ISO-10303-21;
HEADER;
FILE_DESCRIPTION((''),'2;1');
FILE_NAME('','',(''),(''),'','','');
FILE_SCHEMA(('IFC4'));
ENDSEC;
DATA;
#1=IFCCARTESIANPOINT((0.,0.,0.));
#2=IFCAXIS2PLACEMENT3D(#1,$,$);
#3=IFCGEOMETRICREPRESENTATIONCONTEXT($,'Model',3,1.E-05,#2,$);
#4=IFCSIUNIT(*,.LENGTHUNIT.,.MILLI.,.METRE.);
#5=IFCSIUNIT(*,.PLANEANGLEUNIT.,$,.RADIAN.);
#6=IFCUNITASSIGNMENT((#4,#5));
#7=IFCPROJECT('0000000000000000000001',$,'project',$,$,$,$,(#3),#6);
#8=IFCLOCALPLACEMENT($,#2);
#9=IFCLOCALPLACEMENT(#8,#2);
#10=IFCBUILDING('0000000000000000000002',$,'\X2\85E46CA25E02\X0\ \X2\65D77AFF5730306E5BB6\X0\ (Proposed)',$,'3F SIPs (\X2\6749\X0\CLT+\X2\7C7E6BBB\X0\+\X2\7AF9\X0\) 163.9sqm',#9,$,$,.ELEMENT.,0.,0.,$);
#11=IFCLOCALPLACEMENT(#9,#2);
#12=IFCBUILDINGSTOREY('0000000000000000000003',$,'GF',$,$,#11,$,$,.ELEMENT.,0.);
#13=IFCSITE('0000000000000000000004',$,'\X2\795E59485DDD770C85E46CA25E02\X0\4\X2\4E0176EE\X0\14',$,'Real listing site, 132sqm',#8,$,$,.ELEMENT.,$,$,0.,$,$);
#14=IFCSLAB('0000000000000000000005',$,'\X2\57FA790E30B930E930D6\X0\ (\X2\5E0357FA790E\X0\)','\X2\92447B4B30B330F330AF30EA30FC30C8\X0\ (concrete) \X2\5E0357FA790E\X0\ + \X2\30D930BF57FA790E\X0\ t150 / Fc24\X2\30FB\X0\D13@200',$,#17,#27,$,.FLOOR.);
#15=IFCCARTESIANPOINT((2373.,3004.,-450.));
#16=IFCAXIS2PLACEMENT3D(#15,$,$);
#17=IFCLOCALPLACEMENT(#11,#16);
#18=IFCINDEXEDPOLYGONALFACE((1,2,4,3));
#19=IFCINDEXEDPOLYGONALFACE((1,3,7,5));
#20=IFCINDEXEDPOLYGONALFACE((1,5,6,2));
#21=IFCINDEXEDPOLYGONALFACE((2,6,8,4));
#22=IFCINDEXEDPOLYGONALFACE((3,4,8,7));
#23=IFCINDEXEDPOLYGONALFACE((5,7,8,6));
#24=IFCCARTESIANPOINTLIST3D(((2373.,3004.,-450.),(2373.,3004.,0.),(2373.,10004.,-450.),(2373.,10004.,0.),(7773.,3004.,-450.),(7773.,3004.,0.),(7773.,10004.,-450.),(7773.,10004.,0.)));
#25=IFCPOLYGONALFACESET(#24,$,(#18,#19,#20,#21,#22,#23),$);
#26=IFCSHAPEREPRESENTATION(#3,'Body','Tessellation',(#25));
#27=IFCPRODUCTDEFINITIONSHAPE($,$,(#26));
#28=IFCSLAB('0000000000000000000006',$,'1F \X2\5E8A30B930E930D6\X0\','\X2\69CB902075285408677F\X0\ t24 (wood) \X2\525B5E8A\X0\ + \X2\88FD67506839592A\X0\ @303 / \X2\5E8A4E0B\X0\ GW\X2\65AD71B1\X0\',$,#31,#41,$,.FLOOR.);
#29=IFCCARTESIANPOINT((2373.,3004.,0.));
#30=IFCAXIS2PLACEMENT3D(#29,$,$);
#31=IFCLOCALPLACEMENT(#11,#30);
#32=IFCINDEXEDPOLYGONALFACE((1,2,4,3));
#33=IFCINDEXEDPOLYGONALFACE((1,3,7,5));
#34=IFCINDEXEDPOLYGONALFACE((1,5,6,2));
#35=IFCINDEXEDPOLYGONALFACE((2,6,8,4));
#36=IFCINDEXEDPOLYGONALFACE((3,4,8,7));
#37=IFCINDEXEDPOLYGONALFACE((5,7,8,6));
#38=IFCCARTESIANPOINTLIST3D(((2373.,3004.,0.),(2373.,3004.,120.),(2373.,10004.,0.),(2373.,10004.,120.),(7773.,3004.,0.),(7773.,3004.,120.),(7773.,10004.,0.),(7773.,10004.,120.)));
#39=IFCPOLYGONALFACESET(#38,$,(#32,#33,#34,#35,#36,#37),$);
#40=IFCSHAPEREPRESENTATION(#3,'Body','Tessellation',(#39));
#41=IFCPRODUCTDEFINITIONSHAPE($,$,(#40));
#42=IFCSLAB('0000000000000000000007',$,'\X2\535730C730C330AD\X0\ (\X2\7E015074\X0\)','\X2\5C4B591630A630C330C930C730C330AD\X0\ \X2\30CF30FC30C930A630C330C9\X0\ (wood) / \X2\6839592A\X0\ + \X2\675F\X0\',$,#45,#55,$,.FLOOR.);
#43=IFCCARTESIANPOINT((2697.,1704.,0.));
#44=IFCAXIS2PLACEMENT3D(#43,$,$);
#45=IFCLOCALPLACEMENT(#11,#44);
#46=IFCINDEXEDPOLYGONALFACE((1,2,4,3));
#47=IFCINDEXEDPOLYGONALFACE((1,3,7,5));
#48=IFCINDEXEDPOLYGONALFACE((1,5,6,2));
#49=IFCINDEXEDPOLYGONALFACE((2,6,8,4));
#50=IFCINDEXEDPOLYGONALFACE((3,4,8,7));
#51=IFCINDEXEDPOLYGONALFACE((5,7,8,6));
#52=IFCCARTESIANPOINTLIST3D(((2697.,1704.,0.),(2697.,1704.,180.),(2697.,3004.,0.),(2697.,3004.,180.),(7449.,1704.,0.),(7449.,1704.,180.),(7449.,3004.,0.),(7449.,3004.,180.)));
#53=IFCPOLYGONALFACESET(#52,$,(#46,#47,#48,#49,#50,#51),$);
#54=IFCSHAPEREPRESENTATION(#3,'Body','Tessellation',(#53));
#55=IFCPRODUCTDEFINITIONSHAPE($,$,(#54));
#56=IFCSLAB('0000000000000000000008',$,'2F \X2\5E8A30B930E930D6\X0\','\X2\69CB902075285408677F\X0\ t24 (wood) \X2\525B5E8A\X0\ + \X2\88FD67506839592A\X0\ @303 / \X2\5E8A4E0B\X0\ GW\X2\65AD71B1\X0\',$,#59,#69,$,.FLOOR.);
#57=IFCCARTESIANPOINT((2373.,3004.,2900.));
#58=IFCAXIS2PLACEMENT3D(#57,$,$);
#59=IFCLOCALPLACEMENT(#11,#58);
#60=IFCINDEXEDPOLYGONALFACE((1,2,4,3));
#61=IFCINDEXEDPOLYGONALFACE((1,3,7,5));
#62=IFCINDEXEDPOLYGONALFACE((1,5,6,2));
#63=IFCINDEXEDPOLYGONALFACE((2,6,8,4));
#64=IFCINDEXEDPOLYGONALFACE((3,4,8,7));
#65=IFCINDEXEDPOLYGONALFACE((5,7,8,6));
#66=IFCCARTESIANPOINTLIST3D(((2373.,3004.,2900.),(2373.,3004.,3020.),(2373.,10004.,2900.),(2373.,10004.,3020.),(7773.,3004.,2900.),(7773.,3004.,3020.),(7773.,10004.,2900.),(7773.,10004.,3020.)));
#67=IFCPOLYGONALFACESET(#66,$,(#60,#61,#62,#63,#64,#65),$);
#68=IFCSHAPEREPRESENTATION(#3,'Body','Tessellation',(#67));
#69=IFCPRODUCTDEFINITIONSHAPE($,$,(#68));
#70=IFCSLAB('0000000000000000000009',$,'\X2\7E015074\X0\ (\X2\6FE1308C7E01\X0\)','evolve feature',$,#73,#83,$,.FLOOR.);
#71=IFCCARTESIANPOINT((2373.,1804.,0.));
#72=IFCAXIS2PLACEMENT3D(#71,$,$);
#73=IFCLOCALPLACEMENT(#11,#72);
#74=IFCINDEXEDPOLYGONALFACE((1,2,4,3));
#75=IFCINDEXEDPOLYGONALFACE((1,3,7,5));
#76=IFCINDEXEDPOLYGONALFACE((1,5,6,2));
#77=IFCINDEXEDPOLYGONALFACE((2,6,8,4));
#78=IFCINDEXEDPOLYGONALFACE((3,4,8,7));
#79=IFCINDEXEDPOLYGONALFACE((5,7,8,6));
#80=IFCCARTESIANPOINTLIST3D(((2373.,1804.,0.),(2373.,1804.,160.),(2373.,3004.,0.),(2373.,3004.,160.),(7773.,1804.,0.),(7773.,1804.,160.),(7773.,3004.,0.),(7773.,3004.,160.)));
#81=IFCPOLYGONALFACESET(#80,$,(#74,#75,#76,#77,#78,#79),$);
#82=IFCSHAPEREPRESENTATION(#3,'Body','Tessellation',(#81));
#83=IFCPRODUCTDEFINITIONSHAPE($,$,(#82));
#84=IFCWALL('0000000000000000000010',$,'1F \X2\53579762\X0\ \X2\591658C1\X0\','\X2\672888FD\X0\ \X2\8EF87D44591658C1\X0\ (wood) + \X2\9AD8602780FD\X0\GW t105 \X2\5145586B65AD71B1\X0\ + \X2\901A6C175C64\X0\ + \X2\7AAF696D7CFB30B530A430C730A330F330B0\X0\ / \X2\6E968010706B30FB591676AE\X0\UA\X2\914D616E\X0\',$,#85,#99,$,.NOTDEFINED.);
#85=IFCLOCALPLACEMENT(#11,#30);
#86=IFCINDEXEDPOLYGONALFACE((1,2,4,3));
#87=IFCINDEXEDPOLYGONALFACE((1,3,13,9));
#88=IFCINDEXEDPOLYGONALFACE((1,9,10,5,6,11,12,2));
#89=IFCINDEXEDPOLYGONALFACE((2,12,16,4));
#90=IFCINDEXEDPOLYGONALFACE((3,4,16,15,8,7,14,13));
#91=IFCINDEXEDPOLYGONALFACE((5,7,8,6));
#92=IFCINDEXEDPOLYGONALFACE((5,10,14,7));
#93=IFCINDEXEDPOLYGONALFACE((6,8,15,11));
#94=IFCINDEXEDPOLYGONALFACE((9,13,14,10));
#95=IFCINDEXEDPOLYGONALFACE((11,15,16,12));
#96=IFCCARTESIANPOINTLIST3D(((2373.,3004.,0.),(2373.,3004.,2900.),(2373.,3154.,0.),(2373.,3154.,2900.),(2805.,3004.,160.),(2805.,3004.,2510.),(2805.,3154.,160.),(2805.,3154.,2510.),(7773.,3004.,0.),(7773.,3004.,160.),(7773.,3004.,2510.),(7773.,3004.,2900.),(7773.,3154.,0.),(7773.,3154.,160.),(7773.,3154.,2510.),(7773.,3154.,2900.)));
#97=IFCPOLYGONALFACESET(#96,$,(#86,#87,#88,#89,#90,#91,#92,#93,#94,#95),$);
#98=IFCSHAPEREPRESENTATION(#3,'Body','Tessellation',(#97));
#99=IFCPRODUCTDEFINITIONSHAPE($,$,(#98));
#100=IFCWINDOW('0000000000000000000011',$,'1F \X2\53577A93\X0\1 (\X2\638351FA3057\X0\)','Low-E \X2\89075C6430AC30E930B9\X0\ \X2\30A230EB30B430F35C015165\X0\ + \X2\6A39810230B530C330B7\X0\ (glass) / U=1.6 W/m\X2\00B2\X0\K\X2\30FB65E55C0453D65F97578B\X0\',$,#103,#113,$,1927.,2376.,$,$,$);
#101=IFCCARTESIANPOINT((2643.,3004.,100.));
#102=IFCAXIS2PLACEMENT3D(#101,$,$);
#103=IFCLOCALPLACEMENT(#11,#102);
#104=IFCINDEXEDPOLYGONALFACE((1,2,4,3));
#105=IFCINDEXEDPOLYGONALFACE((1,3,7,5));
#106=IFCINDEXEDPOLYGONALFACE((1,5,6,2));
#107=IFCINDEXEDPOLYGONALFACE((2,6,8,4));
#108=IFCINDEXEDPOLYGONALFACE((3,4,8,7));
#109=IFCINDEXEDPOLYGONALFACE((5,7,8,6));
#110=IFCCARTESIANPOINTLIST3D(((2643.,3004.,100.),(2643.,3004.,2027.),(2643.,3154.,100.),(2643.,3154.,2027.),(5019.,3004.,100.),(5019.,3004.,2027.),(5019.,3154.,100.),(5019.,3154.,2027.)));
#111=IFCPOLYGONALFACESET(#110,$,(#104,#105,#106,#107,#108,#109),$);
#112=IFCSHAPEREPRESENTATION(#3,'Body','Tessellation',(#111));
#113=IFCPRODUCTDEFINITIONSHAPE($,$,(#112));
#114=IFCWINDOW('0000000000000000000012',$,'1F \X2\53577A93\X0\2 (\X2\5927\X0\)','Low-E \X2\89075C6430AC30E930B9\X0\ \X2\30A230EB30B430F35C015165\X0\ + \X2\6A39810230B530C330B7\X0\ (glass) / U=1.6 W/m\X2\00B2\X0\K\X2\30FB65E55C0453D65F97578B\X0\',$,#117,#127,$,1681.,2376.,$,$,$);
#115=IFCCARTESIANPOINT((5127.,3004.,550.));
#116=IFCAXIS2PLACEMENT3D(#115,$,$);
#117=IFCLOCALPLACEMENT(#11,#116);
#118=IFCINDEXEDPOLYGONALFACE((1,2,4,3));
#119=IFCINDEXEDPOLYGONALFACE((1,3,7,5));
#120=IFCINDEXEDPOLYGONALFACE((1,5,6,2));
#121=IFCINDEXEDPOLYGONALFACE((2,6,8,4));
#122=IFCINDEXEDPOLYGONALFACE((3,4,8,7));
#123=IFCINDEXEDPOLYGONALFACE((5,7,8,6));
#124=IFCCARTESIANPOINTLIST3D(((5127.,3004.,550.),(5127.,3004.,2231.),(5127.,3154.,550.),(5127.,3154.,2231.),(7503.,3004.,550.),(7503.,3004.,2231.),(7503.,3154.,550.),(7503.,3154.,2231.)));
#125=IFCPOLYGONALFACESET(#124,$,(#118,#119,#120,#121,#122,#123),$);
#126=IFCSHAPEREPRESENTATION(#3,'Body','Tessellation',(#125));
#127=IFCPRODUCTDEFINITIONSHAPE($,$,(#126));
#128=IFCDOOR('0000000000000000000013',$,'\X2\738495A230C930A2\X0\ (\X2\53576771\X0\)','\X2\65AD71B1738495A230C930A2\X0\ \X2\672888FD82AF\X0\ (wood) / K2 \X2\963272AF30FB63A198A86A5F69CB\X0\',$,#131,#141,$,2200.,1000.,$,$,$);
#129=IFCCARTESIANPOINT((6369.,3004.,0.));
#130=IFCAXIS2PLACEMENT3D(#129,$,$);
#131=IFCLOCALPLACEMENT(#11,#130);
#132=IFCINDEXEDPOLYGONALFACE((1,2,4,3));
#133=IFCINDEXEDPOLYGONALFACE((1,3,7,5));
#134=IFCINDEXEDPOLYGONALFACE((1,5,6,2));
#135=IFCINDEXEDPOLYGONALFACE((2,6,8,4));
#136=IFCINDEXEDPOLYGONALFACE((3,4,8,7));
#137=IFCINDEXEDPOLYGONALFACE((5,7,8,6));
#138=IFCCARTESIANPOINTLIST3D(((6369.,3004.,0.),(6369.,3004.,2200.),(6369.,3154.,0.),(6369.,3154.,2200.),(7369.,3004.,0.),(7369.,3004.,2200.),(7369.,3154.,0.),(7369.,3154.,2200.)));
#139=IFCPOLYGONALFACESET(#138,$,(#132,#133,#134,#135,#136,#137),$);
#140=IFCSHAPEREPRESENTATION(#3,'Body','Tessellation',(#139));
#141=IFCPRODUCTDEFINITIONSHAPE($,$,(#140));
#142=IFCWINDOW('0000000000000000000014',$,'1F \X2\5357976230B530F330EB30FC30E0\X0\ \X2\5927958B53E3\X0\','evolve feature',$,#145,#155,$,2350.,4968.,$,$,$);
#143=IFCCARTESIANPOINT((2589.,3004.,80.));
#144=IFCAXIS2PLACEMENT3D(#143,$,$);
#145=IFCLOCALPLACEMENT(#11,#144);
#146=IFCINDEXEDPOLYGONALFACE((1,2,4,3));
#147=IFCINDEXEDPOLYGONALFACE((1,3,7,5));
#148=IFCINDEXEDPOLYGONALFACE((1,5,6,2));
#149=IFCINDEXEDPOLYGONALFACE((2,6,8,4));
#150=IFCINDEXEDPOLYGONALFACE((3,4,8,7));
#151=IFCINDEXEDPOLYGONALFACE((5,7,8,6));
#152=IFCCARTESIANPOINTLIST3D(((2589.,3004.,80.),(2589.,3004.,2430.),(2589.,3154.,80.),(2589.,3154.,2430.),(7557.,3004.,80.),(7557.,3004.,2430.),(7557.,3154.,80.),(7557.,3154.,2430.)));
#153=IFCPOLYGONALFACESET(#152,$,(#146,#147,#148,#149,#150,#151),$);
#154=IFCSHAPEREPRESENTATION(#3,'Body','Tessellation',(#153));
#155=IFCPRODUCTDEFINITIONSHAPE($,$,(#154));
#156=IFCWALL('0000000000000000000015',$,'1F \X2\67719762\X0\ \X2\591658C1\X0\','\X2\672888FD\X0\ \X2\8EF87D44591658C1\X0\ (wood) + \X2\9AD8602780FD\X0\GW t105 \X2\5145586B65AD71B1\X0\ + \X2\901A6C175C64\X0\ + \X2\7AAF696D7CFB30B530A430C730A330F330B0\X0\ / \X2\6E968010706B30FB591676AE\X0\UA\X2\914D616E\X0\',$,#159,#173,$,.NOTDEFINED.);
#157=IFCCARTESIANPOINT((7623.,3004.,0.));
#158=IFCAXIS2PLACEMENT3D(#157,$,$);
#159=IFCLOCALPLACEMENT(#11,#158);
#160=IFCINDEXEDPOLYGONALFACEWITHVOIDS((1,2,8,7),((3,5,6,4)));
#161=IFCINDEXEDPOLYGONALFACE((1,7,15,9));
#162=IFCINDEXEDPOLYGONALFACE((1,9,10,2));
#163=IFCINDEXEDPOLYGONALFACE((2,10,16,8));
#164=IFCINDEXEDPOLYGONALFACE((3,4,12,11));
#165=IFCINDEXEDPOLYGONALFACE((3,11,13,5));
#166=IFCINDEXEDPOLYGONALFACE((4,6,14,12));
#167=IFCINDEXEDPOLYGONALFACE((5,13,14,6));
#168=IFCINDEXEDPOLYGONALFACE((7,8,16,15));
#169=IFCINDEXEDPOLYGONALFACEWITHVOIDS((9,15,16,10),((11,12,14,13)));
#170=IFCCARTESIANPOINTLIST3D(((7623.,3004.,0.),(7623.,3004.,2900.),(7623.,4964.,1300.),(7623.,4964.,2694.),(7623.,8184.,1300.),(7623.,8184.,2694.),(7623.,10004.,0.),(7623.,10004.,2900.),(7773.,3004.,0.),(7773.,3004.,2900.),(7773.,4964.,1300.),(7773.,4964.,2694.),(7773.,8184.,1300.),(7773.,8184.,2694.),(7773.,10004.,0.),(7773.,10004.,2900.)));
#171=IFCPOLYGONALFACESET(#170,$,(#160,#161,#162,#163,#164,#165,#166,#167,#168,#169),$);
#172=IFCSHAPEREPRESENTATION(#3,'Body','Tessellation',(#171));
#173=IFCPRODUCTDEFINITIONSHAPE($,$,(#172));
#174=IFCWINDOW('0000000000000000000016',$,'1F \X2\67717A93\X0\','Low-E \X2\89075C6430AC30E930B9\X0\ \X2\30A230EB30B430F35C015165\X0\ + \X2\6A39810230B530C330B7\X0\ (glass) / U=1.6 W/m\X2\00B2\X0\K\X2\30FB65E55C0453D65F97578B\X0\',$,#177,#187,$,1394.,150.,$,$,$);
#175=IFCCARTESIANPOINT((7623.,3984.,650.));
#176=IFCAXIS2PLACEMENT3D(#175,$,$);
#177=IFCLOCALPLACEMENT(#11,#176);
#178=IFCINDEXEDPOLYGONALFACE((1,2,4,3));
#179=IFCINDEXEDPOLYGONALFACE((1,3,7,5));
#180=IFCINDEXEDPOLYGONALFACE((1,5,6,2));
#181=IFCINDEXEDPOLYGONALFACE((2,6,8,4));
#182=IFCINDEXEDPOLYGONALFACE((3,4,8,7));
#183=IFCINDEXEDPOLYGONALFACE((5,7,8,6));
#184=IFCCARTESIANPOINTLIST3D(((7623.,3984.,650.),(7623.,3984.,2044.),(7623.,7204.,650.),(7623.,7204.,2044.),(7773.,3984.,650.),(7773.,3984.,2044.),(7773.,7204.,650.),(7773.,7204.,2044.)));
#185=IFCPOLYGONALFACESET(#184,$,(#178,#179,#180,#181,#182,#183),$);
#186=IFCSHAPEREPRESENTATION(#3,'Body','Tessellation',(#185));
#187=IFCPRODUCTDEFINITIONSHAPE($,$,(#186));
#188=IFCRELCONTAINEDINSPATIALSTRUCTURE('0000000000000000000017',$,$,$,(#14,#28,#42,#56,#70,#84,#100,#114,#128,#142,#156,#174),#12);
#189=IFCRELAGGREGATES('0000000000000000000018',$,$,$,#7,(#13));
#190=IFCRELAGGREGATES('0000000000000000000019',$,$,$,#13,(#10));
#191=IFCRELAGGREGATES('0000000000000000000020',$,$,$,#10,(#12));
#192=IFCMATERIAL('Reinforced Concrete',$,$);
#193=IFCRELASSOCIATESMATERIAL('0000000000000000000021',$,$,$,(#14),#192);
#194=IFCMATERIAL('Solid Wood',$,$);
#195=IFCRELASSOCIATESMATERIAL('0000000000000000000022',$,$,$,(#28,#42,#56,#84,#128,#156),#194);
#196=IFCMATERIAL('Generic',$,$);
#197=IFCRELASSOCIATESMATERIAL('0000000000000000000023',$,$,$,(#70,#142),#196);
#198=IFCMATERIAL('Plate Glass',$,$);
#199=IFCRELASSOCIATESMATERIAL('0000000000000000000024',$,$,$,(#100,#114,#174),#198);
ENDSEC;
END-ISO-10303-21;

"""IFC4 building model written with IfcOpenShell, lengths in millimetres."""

from ifc_helpers import new_model, si_unit, frame, frame_2d, origin, place, context, project, spatial, rectangle, extrude, material, element, fill, save


model = new_model("IFC4")

# Units and contexts
model_context = context("Model", 3, precision=1e-05, world=origin())
ifc_project = project(units=[si_unit("LENGTHUNIT", "METRE", prefix="MILLI"), si_unit("PLANEANGLEUNIT", "RADIAN")], contexts=[model_context])

# Site, building, storey
site_placement = place(None, origin())
site = spatial("IfcSite", under=ifc_project, at=site_placement, Name="神奈川県藤沢市4丁目14", ObjectType="Real listing site, 132sqm", CompositionType="ELEMENT", RefElevation=0.0)
building_placement = place(site_placement, origin())
building = spatial("IfcBuilding", under=site, at=building_placement, Name="藤沢市 旗竿地の家 (Proposed)", ObjectType="3F SIPs (杉CLT+籾殻+竹) 163.9sqm", CompositionType="ELEMENT", ElevationOfRefHeight=0.0, ElevationOfTerrain=0.0)
storey_placement = place(building_placement, origin())
storey = spatial("IfcBuildingStorey", under=building, at=storey_placement, Name="GF", CompositionType="ELEMENT", Elevation=0.0)

# Slabs
ifc_material_1 = material(Name="Reinforced Concrete")
slab_1_placement = place(storey_placement, frame((2373.0, 3004.0, -450.0)))
element("IfcSlab", 1, at=slab_1_placement, inside=storey, material=ifc_material_1, Name="基礎スラブ (布基礎)", Description="鉄筋コンクリート (concrete) 布基礎 + ベタ基礎 t150 / Fc24・D13@200", PredefinedType="FLOOR", context=model_context, shape_type="SweptSolid", body=[
    extrude(rectangle(XDim=5400.0, YDim=7000.0, at=frame_2d((2700.0, 3500.0))), frame((2373.0, 3004.0, -450.0)), (0.0, 0.0, 1.0), 450.0),
])
ifc_material_2 = material(Name="Solid Wood")
slab_2_placement = place(storey_placement, frame((2373.0, 3004.0, 0.0)))
element("IfcSlab", 2, at=slab_2_placement, inside=storey, material=ifc_material_2, Name="1F 床スラブ", Description="構造用合板 t24 (wood) 剛床 + 製材根太 @303 / 床下 GW断熱", PredefinedType="FLOOR", context=model_context, shape_type="SweptSolid", body=[
    extrude(rectangle(XDim=5400.0, YDim=7000.0, at=frame_2d((2700.0, 3500.0))), frame((2373.0, 3004.0, 0.0)), (0.0, 0.0, 1.0), 120.0),
])
slab_3_placement = place(storey_placement, frame((2697.0, 1704.0, 0.0)))
element("IfcSlab", 3, at=slab_3_placement, inside=storey, material=ifc_material_2, Name="南デッキ (縁側)", Description="屋外ウッドデッキ ハードウッド (wood) / 根太 + 束", PredefinedType="FLOOR", context=model_context, shape_type="SweptSolid", body=[
    extrude(rectangle(XDim=4752.0, YDim=1300.0, at=frame_2d((2376.0, 650.0))), frame((2697.0, 1704.0, 0.0)), (0.0, 0.0, 1.0), 180.0),
])
slab_4_placement = place(storey_placement, frame((2373.0, 3004.0, 2900.0)))
element("IfcSlab", 4, at=slab_4_placement, inside=storey, material=ifc_material_2, Name="2F 床スラブ", Description="構造用合板 t24 (wood) 剛床 + 製材根太 @303 / 床下 GW断熱", PredefinedType="FLOOR", context=model_context, shape_type="SweptSolid", body=[
    extrude(rectangle(XDim=5400.0, YDim=7000.0, at=frame_2d((2700.0, 3500.0))), frame((2373.0, 3004.0, 2900.0)), (0.0, 0.0, 1.0), 120.0),
])
ifc_material_3 = material(Name="Generic")
slab_5_placement = place(storey_placement, frame((2373.0, 1804.0, 0.0)))
element("IfcSlab", 5, at=slab_5_placement, inside=storey, material=ifc_material_3, Name="縁側 (濡れ縁)", Description="evolve feature", PredefinedType="FLOOR", context=model_context, shape_type="SweptSolid", body=[
    extrude(rectangle(XDim=5400.0, YDim=1200.0, at=frame_2d((2700.0, 600.0))), frame((2373.0, 1804.0, 0.0)), (0.0, 0.0, 1.0), 160.0),
])

# Wall, openings, windows, door
wall_1_placement = place(storey_placement, frame((2373.0, 3004.0, 0.0)))
wall_1 = element("IfcWall", 6, at=wall_1_placement, inside=storey, material=ifc_material_2, Name="1F 南面 外壁", Description="木製 軸組外壁 (wood) + 高性能GW t105 充填断熱 + 通気層 + 窯業系サイディング / 準耐火・外皮UA配慮", PredefinedType="NOTDEFINED", context=model_context, shape_type="SweptSolid", body=[
    extrude(rectangle(XDim=5400.0, YDim=150.0, at=frame_2d((2700.0, 75.0))), frame((2373.0, 3004.0, 0.0)), (0.0, 0.0, 1.0), 2900.0),
])
opening_1_placement = place(storey_placement, frame((2643.0, 3004.0, 100.0)))
opening_1 = element("IfcOpeningElement", 7, at=opening_1_placement, cuts=wall_1, PredefinedType="NOTDEFINED", context=model_context, shape_type="SweptSolid", body=[
    extrude(rectangle(XDim=2376.0, YDim=150.0, at=frame_2d((1188.0, 75.0))), frame((2643.0, 3004.0, 100.0)), (0.0, 0.0, 1.0), 1927.0),
])
opening_2_placement = place(storey_placement, frame((5127.0, 3004.0, 550.0)))
opening_2 = element("IfcOpeningElement", 8, at=opening_2_placement, cuts=wall_1, PredefinedType="NOTDEFINED", context=model_context, shape_type="SweptSolid", body=[
    extrude(rectangle(XDim=2376.0, YDim=150.0, at=frame_2d((1188.0, 75.0))), frame((5127.0, 3004.0, 550.0)), (0.0, 0.0, 1.0), 1681.0),
])
opening_3_placement = place(storey_placement, frame((6369.0, 3004.0, 0.0)))
opening_3 = element("IfcOpeningElement", 9, at=opening_3_placement, cuts=wall_1, PredefinedType="NOTDEFINED", context=model_context, shape_type="SweptSolid", body=[
    extrude(rectangle(XDim=1000.0, YDim=150.0, at=frame_2d((500.0, 75.0))), frame((6369.0, 3004.0, 0.0)), (0.0, 0.0, 1.0), 2200.0),
])
opening_4_placement = place(storey_placement, frame((2589.0, 3004.0, 80.0)))
opening_4 = element("IfcOpeningElement", 10, at=opening_4_placement, cuts=wall_1, PredefinedType="NOTDEFINED", context=model_context, shape_type="SweptSolid", body=[
    extrude(rectangle(XDim=4968.0, YDim=150.0, at=frame_2d((2484.0, 75.0))), frame((2589.0, 3004.0, 80.0)), (0.0, 0.0, 1.0), 2350.0),
])
ifc_material_4 = material(Name="Plate Glass")
window_1_placement = place(storey_placement, frame((2643.0, 3004.0, 100.0)))
window_1 = element("IfcWindow", 11, at=window_1_placement, inside=storey, material=ifc_material_4, Name="1F 南窓1 (掃出し)", Description="Low-E 複層ガラス アルゴン封入 + 樹脂サッシ (glass) / U=1.6 W/m²K・日射取得型", OverallHeight=1927.0, OverallWidth=2376.0, context=model_context, shape_type="SweptSolid", body=[
    extrude(rectangle(XDim=2376.0, YDim=150.0, at=frame_2d((1188.0, 75.0))), frame((2643.0, 3004.0, 100.0)), (0.0, 0.0, 1.0), 1927.0),
])
fill(opening_1, window_1)
window_2_placement = place(storey_placement, frame((5127.0, 3004.0, 550.0)))
window_2 = element("IfcWindow", 12, at=window_2_placement, inside=storey, material=ifc_material_4, Name="1F 南窓2 (大)", Description="Low-E 複層ガラス アルゴン封入 + 樹脂サッシ (glass) / U=1.6 W/m²K・日射取得型", OverallHeight=1681.0, OverallWidth=2376.0, context=model_context, shape_type="SweptSolid", body=[
    extrude(rectangle(XDim=2376.0, YDim=150.0, at=frame_2d((1188.0, 75.0))), frame((5127.0, 3004.0, 550.0)), (0.0, 0.0, 1.0), 1681.0),
])
fill(opening_2, window_2)
door_placement = place(storey_placement, frame((6369.0, 3004.0, 0.0)))
door = element("IfcDoor", 13, at=door_placement, inside=storey, material=ifc_material_2, Name="玄関ドア (南東)", Description="断熱玄関ドア 木製芯 (wood) / K2 防犯・採風機構", OverallHeight=2200.0, OverallWidth=1000.0, context=model_context, shape_type="SweptSolid", body=[
    extrude(rectangle(XDim=1000.0, YDim=150.0, at=frame_2d((500.0, 75.0))), frame((6369.0, 3004.0, 0.0)), (0.0, 0.0, 1.0), 2200.0),
])
fill(opening_3, door)
window_3_placement = place(storey_placement, frame((2589.0, 3004.0, 80.0)))
window_3 = element("IfcWindow", 14, at=window_3_placement, inside=storey, material=ifc_material_3, Name="1F 南面サンルーム 大開口", Description="evolve feature", OverallHeight=2350.0, OverallWidth=4968.0, context=model_context, shape_type="SweptSolid", body=[
    extrude(rectangle(XDim=4968.0, YDim=150.0, at=frame_2d((2484.0, 75.0))), frame((2589.0, 3004.0, 80.0)), (0.0, 0.0, 1.0), 2350.0),
])
fill(opening_4, window_3)

# Wall, opening, window
wall_2_placement = place(storey_placement, frame((7623.0, 3004.0, 0.0)))
wall_2 = element("IfcWall", 15, at=wall_2_placement, inside=storey, material=ifc_material_2, Name="1F 東面 外壁", Description="木製 軸組外壁 (wood) + 高性能GW t105 充填断熱 + 通気層 + 窯業系サイディング / 準耐火・外皮UA配慮", PredefinedType="NOTDEFINED", context=model_context, shape_type="SweptSolid", body=[
    extrude(rectangle(XDim=150.0, YDim=7000.0, at=frame_2d((75.0, 3500.0))), frame((7623.0, 3004.0, 0.0)), (0.0, 0.0, 1.0), 2900.0),
])
opening_5_placement = place(storey_placement, frame((7623.0, 3984.0, 650.0)))
opening_5 = element("IfcOpeningElement", 16, at=opening_5_placement, cuts=wall_2, PredefinedType="NOTDEFINED", context=model_context, shape_type="SweptSolid", body=[
    extrude(rectangle(XDim=150.0, YDim=3220.0, at=frame_2d((75.0, 1610.0))), frame((7623.0, 3984.0, 650.0)), (0.0, 0.0, 1.0), 1394.0),
])
window_4_placement = place(storey_placement, frame((7623.0, 3984.0, 650.0)))
window_4 = element("IfcWindow", 17, at=window_4_placement, inside=storey, material=ifc_material_4, Name="1F 東窓", Description="Low-E 複層ガラス アルゴン封入 + 樹脂サッシ (glass) / U=1.6 W/m²K・日射取得型", OverallHeight=1394.0, OverallWidth=150.0, context=model_context, shape_type="SweptSolid", body=[
    extrude(rectangle(XDim=150.0, YDim=3220.0, at=frame_2d((75.0, 1610.0))), frame((7623.0, 3984.0, 650.0)), (0.0, 0.0, 1.0), 1394.0),
])
fill(opening_5, window_4)

save(model, "model.ifc")
